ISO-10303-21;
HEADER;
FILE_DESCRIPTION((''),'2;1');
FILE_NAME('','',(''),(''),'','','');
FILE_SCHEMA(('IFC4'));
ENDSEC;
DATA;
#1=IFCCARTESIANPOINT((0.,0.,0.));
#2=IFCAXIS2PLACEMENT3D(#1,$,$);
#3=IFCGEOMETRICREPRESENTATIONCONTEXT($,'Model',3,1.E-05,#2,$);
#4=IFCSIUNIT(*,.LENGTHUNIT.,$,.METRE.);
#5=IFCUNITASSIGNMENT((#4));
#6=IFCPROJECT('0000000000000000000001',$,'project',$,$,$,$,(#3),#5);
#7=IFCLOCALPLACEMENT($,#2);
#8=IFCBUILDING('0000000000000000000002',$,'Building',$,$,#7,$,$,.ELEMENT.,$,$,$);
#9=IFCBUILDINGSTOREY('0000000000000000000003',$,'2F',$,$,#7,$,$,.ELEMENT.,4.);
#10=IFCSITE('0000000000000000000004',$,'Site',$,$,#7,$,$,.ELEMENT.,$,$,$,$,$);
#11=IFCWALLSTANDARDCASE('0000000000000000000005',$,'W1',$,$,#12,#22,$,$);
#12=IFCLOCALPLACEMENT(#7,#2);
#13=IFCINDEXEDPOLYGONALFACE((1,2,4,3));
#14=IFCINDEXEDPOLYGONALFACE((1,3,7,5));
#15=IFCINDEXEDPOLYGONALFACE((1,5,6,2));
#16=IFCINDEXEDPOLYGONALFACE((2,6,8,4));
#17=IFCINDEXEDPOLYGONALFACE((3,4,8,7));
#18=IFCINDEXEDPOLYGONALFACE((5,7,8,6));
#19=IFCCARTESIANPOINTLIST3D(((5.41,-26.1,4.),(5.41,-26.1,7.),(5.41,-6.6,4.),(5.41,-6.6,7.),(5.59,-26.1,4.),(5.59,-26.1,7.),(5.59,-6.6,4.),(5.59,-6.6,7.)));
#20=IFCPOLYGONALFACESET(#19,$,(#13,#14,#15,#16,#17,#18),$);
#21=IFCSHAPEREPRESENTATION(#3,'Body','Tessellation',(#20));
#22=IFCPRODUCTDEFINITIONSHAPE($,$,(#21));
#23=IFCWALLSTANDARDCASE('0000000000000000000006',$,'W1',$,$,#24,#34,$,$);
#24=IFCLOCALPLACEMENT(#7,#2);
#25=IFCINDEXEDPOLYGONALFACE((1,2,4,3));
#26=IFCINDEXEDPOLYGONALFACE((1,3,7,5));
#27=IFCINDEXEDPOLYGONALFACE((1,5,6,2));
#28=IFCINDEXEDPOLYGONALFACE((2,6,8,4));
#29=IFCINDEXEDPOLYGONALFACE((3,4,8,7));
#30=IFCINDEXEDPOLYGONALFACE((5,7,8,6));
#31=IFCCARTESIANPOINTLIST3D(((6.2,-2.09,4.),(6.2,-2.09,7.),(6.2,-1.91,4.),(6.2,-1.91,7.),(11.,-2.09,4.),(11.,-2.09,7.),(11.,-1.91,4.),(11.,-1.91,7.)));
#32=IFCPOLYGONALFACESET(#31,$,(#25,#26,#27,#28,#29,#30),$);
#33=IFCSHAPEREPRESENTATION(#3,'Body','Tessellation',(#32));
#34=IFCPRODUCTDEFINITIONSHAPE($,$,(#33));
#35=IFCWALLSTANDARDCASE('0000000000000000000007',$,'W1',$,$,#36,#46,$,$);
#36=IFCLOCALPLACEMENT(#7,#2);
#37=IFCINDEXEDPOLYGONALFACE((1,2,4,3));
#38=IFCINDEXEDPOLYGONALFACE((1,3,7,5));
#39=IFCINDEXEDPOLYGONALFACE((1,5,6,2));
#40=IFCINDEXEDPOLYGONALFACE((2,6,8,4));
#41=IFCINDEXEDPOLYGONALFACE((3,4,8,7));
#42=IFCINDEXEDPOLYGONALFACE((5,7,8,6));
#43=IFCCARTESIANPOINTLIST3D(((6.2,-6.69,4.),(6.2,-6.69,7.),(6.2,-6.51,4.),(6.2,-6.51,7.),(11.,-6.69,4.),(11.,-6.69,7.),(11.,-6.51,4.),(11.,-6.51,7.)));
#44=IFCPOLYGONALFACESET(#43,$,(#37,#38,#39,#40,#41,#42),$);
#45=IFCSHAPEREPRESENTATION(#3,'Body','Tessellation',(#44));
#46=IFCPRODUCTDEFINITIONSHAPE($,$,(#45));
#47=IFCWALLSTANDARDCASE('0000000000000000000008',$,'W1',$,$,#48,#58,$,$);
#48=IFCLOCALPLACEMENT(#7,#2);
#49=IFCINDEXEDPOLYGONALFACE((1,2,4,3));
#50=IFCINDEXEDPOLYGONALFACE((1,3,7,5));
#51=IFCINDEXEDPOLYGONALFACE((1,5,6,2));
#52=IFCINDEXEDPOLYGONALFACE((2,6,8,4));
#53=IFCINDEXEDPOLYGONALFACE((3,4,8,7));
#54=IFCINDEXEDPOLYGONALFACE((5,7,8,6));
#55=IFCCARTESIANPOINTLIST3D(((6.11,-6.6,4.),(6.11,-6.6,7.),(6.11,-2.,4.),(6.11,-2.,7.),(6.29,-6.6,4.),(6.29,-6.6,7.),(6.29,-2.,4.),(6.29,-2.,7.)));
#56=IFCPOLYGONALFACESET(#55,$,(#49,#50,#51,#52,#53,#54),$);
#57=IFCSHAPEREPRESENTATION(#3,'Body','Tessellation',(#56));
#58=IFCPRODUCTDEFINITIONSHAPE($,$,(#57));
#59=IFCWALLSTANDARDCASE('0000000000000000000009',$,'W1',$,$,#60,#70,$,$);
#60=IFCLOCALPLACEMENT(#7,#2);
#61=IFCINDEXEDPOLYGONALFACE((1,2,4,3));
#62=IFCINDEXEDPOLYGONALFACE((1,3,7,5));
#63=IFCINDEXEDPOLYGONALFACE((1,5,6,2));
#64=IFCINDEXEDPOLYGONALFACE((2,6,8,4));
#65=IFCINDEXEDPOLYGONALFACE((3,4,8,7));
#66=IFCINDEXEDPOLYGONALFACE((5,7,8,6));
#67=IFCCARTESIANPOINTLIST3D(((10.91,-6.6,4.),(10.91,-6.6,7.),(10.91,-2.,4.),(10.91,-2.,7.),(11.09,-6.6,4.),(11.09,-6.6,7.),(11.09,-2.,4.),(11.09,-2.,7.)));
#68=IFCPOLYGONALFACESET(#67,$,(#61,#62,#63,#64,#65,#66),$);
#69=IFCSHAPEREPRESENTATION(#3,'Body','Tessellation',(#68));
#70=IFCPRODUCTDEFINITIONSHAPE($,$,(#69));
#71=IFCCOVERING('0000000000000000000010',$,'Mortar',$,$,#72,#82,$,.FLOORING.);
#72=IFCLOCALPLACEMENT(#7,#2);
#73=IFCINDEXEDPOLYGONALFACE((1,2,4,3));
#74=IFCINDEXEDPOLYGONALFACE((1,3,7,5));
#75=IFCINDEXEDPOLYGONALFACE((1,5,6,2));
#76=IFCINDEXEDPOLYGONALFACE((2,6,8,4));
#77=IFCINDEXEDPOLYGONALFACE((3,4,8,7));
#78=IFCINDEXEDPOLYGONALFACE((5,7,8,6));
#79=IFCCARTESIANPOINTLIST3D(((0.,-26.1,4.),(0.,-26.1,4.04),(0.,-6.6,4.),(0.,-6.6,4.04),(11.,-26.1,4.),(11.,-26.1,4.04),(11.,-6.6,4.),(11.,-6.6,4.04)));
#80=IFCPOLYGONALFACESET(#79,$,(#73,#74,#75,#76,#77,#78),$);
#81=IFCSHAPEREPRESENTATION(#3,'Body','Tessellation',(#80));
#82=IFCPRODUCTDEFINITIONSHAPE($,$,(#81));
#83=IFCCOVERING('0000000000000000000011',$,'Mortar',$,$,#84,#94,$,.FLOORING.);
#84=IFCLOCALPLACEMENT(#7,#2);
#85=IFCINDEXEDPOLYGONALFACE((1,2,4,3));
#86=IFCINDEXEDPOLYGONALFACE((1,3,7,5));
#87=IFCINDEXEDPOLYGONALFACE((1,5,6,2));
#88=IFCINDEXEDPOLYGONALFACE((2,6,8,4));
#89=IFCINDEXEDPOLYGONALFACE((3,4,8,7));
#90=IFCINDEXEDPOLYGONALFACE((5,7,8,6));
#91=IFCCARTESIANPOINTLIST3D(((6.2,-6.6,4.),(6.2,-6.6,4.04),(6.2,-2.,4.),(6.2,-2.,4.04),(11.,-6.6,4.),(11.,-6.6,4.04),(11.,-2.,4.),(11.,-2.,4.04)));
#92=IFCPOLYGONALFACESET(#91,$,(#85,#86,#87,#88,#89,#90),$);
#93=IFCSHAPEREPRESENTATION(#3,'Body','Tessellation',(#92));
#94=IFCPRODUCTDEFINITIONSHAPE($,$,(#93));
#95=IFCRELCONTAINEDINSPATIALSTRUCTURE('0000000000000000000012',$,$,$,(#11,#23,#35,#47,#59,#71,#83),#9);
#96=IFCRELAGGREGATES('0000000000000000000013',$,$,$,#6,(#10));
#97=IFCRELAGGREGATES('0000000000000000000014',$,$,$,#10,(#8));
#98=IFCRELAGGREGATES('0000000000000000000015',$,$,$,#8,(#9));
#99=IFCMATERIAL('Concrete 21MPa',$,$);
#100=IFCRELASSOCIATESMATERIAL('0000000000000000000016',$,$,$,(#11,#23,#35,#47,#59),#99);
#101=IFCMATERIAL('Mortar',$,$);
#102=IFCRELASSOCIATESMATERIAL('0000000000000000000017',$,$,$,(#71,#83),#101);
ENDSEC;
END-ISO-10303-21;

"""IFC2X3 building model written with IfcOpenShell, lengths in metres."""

from ifc_helpers import new_model, si_unit, frame, origin, origin_2d, place, context, project, spatial, rectangle, extrude, material, element, save


model = new_model("IFC2X3")

# Units and contexts
model_context = context("Model", 3, precision=1e-05, world=origin())
ifc_project = project(units=[si_unit("LENGTHUNIT", "METRE")], contexts=[model_context])

# Site, building, storey
placement = place(None, origin())
site = spatial("IfcSite", under=ifc_project, at=placement, Name="Site", CompositionType="ELEMENT")
building = spatial("IfcBuilding", under=site, at=placement, Name="Building", CompositionType="ELEMENT")
storey = spatial("IfcBuildingStorey", under=building, at=placement, Name="2F", CompositionType="ELEMENT", Elevation=4.0)

# Shared definitions
ifc_material_1 = material(Name="Concrete 21MPa")

# Walls
wall_placement = place(None, frame((5.5, -16.35, 4.0)))
element("IfcWallStandardCase", 1, at=wall_placement, inside=storey, material=ifc_material_1, Name="W1", context=model_context, shape_type="SweptSolid", body=[
    extrude(rectangle(XDim=0.18, YDim=19.5, at=origin_2d()), origin(), (0.0, 0.0, 1.0), 3.0),
])
for number, where, name in (
    (2, (8.6, -2.0, 4.0), "W1"),
    (3, (8.6, -6.6, 4.0), "W1"),
):
    element("IfcWallStandardCase", number, at=place(None, frame(where)), inside=storey, material=ifc_material_1, Name=name, context=model_context, shape_type="SweptSolid", body=[
        extrude(rectangle(XDim=4.8, YDim=0.18, at=origin_2d()), origin(), (0.0, 0.0, 1.0), 3.0),
    ])
for number, where, name in (
    (4, (6.2, -4.3, 4.0), "W1"),
    (5, (11.0, -4.3, 4.0), "W1"),
):
    element("IfcWallStandardCase", number, at=place(None, frame(where)), inside=storey, material=ifc_material_1, Name=name, context=model_context, shape_type="SweptSolid", body=[
        extrude(rectangle(XDim=0.18, YDim=4.6, at=origin_2d()), origin(), (0.0, 0.0, 1.0), 3.0),
    ])

# Coverings
ifc_material_2 = material(Name="Mortar")
covering_1_placement = place(None, frame((5.5, -16.35, 4.0)))
element("IfcCovering", 6, at=covering_1_placement, inside=storey, material=ifc_material_2, Name="Mortar", PredefinedType="FLOORING", context=model_context, shape_type="SweptSolid", body=[
    extrude(rectangle(XDim=11.0, YDim=19.5, at=origin_2d()), origin(), (0.0, 0.0, 1.0), 0.04),
])
covering_2_placement = place(None, frame((8.6, -4.3, 4.0)))
element("IfcCovering", 7, at=covering_2_placement, inside=storey, material=ifc_material_2, Name="Mortar", PredefinedType="FLOORING", context=model_context, shape_type="SweptSolid", body=[
    extrude(rectangle(XDim=4.8, YDim=4.6, at=origin_2d()), origin(), (0.0, 0.0, 1.0), 0.04),
])

save(model, "model.ifc")
